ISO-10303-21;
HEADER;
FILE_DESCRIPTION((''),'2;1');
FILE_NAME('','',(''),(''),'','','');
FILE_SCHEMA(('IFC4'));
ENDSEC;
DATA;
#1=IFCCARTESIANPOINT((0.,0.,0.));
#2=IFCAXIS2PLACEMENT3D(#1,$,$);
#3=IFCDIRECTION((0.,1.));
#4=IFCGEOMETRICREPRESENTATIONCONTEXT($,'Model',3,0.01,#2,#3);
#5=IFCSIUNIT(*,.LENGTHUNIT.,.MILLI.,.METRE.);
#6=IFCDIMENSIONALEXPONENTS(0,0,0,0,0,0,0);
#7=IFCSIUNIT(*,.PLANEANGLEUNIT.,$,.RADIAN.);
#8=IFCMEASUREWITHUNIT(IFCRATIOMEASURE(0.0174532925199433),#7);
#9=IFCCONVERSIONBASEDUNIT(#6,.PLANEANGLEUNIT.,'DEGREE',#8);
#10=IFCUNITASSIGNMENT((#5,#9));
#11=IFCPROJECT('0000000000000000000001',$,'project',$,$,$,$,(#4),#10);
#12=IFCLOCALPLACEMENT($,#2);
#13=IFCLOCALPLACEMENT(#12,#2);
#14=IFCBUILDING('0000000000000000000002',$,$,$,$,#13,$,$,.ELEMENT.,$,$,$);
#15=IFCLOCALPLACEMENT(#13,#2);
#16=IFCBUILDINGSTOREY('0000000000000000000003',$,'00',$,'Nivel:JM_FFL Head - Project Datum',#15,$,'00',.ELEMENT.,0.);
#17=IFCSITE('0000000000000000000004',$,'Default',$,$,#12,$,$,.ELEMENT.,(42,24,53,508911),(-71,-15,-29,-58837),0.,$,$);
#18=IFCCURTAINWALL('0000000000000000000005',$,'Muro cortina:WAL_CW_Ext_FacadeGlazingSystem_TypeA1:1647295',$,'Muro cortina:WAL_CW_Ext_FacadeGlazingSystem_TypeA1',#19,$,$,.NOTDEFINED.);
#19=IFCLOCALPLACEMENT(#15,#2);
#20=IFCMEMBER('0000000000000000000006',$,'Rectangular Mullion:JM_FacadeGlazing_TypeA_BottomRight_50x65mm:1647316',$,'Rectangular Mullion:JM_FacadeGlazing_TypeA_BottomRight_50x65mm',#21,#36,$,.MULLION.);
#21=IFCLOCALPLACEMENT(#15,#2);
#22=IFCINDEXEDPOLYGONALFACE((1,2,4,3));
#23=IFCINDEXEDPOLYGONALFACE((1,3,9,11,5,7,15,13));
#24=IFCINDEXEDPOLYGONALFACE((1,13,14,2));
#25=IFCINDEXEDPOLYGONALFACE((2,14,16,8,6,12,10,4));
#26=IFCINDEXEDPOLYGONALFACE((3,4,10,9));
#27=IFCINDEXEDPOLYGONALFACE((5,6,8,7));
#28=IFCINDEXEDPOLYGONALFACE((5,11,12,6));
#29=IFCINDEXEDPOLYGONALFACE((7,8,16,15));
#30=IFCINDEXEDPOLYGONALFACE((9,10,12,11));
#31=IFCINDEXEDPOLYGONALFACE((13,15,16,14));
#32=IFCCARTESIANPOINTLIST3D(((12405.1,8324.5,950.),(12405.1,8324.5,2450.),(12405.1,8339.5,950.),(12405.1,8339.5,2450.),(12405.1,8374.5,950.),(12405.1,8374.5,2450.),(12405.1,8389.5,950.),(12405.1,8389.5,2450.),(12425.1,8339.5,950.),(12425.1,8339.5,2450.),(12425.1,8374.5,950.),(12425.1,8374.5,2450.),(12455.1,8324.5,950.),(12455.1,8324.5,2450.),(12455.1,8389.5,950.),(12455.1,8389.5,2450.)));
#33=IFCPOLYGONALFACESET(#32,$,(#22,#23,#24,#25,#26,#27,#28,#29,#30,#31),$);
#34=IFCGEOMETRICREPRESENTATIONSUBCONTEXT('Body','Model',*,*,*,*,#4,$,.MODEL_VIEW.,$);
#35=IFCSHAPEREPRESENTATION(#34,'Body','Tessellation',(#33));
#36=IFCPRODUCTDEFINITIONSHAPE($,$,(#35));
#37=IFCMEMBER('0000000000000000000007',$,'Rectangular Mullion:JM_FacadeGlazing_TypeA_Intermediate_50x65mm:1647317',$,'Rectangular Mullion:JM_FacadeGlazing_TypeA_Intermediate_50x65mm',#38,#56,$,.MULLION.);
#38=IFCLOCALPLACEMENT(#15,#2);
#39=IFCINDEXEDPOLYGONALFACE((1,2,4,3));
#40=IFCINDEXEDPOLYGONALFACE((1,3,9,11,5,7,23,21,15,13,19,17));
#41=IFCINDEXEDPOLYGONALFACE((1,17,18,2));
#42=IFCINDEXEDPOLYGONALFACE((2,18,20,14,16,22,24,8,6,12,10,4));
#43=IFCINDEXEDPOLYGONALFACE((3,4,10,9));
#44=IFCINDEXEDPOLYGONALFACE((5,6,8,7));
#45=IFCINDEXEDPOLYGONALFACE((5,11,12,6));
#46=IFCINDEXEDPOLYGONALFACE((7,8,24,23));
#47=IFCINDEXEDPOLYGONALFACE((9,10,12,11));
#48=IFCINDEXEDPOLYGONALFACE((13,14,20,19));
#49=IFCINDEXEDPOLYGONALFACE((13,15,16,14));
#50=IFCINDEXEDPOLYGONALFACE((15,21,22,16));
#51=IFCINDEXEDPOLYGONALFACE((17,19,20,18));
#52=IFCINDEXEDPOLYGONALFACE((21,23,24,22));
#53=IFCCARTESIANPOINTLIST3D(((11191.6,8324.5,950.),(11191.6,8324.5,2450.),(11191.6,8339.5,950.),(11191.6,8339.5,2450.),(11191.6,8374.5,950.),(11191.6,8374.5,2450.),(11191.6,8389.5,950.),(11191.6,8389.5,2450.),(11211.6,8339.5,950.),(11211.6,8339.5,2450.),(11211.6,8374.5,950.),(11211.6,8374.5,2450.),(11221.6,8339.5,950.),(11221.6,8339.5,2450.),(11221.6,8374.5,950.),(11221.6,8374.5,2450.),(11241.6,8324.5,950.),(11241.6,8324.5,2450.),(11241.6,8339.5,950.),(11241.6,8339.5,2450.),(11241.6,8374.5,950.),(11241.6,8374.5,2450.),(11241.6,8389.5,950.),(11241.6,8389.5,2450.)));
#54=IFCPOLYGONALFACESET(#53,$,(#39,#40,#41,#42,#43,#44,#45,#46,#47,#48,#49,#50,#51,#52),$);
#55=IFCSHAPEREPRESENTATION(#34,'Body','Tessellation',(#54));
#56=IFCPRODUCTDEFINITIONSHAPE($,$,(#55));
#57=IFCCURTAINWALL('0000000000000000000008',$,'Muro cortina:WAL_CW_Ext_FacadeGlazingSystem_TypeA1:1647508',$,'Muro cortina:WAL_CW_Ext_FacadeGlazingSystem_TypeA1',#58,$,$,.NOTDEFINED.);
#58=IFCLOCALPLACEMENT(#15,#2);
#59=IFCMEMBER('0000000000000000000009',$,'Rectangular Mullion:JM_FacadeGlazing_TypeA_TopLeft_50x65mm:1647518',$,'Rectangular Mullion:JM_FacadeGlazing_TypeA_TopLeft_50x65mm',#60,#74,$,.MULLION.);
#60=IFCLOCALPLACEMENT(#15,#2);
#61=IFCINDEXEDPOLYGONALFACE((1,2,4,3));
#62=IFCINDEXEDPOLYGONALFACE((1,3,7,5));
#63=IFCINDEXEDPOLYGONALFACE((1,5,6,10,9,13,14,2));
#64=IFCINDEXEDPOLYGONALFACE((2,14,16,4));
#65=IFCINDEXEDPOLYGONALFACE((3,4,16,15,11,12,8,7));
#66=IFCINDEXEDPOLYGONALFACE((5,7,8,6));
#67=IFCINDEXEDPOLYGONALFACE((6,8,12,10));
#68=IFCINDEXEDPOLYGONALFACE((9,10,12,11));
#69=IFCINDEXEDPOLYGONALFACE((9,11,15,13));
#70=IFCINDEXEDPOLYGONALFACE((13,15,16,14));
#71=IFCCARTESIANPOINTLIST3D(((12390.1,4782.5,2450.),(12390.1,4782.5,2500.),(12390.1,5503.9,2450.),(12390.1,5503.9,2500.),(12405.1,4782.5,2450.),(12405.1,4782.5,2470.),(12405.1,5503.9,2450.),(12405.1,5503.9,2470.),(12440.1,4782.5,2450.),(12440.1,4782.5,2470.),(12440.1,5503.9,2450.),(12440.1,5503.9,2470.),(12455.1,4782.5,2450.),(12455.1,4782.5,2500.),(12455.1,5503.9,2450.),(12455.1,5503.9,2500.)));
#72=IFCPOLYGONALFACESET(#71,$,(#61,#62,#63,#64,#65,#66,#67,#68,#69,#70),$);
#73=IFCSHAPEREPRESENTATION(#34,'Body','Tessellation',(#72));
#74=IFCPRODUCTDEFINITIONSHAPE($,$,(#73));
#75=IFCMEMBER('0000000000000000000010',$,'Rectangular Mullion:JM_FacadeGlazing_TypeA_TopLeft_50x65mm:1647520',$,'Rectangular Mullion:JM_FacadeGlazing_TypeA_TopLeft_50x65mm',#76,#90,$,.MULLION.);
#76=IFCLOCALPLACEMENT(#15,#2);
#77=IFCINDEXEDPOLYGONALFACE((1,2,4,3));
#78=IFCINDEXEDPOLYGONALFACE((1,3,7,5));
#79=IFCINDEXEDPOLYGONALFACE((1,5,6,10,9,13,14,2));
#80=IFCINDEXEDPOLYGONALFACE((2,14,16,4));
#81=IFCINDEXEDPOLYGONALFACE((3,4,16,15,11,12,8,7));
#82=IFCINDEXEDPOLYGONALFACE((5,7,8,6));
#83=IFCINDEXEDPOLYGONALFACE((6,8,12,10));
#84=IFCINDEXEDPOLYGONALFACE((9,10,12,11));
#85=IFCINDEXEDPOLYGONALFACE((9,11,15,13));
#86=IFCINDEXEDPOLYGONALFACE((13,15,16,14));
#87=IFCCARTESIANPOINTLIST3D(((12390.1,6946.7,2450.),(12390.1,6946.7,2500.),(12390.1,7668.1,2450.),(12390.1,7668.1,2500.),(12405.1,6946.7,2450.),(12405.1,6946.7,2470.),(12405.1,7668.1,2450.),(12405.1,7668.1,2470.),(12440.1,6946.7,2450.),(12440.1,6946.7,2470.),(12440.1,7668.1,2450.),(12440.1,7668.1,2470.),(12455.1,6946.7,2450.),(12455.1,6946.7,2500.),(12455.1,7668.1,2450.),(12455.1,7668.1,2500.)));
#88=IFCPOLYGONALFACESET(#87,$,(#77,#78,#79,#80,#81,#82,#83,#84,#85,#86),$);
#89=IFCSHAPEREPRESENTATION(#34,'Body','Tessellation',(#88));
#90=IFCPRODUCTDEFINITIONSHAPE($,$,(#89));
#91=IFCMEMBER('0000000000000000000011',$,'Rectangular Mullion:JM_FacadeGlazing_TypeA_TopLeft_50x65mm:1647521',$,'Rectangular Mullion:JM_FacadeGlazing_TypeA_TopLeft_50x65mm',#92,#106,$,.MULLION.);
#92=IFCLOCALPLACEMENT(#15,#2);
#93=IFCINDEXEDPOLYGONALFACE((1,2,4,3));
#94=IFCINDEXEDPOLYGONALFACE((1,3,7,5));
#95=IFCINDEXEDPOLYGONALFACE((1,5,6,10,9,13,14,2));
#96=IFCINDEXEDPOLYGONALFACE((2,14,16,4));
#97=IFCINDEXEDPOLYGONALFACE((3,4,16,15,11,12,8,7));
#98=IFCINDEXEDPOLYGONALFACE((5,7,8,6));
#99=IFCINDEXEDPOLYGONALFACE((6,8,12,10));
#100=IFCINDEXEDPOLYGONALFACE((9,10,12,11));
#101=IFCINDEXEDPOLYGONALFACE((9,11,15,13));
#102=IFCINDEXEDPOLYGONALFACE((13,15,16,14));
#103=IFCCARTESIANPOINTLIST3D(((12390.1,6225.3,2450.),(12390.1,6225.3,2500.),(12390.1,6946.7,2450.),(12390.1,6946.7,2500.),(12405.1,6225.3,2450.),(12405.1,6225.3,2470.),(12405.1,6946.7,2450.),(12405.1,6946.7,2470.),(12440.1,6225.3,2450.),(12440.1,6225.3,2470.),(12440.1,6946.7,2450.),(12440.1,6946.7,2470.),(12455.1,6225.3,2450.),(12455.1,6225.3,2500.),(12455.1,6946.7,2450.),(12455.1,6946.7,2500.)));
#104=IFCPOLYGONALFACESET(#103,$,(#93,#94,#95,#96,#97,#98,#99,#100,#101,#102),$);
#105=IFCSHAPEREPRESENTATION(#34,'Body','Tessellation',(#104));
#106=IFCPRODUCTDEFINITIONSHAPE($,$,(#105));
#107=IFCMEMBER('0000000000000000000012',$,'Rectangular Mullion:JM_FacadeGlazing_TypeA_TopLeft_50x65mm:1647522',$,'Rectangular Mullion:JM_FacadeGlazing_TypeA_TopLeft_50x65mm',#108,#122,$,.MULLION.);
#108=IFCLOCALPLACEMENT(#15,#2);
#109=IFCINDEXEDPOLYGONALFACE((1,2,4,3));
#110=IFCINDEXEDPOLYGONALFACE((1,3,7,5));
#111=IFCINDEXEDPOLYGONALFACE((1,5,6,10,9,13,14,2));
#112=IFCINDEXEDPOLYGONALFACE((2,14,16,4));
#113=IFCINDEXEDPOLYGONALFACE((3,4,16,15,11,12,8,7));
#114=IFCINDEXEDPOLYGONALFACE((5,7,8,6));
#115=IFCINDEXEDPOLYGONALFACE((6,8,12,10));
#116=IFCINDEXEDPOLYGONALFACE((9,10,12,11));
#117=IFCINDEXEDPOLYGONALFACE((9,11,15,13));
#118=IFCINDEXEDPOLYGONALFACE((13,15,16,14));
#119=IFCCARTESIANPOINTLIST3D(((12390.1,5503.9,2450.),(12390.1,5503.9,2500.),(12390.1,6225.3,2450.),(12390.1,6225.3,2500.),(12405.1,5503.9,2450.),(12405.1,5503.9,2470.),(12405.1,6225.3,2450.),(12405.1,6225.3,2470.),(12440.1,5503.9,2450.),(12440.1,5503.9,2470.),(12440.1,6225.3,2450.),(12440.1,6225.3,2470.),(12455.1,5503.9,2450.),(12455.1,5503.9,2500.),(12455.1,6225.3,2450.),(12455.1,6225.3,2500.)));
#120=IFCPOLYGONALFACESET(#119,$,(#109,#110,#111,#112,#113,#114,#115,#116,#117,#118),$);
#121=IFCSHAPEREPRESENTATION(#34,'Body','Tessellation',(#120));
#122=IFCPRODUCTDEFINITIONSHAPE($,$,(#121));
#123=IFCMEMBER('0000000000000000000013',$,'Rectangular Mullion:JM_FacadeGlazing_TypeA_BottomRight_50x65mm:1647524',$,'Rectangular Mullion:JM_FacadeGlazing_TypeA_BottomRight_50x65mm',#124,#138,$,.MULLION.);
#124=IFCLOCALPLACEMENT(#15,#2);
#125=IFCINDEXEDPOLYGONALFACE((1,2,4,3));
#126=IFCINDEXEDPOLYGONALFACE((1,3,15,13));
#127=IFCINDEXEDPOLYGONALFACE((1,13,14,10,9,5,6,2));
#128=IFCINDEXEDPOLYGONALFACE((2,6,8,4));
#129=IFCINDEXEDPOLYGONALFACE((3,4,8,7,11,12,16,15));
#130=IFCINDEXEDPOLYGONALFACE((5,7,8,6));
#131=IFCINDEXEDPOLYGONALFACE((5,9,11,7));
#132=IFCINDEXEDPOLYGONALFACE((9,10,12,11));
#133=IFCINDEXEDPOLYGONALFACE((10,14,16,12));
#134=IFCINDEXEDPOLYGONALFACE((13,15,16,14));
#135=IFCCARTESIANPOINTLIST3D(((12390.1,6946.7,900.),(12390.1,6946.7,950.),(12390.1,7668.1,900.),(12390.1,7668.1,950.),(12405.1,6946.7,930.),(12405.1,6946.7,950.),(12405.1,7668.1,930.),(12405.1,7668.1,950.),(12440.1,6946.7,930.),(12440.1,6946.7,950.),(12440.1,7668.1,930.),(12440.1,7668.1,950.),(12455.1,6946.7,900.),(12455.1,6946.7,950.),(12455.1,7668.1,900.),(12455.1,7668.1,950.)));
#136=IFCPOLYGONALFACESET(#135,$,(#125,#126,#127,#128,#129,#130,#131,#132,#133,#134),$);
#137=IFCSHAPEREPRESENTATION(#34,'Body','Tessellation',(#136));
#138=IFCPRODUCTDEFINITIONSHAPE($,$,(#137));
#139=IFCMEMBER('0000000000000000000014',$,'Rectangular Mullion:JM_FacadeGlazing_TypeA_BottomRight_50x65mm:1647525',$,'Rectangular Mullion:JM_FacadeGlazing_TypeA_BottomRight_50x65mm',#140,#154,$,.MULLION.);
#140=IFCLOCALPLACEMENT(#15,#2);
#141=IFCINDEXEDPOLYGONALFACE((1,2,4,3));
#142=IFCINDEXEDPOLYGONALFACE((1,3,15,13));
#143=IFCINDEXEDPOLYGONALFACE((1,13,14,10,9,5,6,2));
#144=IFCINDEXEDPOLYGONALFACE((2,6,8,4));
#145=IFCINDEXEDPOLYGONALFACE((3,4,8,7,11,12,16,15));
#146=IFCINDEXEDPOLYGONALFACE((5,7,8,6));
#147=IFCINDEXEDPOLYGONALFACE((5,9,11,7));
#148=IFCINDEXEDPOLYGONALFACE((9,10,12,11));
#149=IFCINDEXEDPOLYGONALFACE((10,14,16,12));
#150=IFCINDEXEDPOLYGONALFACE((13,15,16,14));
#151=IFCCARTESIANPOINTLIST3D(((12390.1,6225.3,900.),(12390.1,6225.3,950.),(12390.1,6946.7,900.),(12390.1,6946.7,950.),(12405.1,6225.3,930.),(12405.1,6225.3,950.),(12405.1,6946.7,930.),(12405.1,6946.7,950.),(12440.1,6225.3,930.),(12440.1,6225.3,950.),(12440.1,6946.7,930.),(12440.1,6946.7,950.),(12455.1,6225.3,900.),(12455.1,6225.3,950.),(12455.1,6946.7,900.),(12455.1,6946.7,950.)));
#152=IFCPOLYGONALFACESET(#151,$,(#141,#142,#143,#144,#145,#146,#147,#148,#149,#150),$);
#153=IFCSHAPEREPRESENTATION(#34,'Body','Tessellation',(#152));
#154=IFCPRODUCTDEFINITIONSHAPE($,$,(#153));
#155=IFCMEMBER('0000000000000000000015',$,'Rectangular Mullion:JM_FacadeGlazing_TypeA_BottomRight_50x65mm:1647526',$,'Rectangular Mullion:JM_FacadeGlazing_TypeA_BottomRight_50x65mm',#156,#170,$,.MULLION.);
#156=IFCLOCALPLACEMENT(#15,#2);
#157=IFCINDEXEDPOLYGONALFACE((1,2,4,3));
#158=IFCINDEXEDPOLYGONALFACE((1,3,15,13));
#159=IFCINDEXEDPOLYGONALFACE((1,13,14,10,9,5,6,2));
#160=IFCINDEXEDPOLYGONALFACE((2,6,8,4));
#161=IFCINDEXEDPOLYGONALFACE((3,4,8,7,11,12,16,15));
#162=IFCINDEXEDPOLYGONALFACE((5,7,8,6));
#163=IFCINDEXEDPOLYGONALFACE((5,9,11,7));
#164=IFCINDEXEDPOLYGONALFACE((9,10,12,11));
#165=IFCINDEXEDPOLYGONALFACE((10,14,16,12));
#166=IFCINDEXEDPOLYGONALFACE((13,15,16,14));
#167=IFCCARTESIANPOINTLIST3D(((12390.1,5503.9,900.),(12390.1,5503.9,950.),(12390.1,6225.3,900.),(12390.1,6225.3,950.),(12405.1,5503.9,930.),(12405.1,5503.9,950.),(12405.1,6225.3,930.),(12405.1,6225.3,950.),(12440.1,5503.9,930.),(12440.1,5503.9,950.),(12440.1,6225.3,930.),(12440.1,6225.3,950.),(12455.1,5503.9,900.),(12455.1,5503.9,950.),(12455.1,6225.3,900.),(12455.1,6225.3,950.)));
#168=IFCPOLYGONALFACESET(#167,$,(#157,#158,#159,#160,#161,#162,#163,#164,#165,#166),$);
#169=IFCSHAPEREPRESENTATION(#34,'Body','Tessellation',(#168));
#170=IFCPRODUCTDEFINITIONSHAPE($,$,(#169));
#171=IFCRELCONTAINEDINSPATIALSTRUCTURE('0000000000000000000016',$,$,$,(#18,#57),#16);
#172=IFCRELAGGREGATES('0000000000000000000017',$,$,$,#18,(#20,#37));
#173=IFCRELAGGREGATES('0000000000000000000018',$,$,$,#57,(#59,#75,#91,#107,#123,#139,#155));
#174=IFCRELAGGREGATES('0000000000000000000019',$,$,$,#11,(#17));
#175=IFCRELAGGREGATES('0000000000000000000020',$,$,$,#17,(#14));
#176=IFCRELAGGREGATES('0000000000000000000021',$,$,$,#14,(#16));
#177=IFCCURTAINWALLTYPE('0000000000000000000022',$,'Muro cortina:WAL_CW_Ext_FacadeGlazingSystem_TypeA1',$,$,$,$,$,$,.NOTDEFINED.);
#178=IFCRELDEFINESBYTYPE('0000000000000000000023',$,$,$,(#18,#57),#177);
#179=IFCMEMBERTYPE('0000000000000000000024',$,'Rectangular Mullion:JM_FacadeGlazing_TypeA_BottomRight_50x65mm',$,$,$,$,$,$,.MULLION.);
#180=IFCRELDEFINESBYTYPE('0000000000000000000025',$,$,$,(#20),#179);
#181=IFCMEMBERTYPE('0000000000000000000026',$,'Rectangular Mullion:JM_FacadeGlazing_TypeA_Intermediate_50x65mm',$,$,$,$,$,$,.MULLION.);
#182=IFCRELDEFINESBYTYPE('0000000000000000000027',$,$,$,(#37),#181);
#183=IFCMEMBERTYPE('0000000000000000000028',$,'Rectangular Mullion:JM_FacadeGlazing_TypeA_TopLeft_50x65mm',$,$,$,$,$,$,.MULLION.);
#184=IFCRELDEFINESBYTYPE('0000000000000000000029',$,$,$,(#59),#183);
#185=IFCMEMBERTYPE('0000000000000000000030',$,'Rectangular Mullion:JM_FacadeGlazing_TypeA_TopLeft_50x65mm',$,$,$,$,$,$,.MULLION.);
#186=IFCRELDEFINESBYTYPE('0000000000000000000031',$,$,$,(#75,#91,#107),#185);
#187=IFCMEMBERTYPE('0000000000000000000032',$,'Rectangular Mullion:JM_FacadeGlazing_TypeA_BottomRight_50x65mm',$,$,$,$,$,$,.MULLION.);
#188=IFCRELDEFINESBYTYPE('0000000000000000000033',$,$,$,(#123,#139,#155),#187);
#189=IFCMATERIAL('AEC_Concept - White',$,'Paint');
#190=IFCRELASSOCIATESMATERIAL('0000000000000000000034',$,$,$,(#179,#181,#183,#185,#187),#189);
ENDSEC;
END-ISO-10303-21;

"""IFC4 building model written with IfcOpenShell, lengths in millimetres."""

from ifc_helpers import new_model, entity, si_unit, converted_unit, direction, frame, origin, place, context, subcontext, project, spatial, indexed_curve, outline, extrude, source, transform, mapped, material, type_object, type_shapes, element, aggregate, save


model = new_model("IFC4")

# Units and contexts
model_context = context("Model", 3, precision=0.01, world=origin(), true_north=direction((0.0, 1.0)))
body_context = subcontext(model_context, "Body", "Model", "MODEL_VIEW")
ifc_project = project(units=[si_unit("LENGTHUNIT", "METRE", prefix="MILLI"), converted_unit("PLANEANGLEUNIT", "DEGREE", entity("IfcRatioMeasure", 0.0174532925199433), si_unit("PLANEANGLEUNIT", "RADIAN"), dimensions=[0, 0, 0, 0, 0, 0, 0])], contexts=[model_context])

# Site, building, storey
site_placement = place(None, origin())
site = spatial("IfcSite", under=ifc_project, at=site_placement, Name="Default", CompositionType="ELEMENT", RefLatitude=(42, 24, 53, 508911), RefLongitude=(-71, -15, -29, -58837), RefElevation=0.0)
building_placement = place(site_placement, origin())
building = spatial("IfcBuilding", under=site, at=building_placement, CompositionType="ELEMENT")
storey_placement = place(building_placement, origin())
storey = spatial("IfcBuildingStorey", under=building, at=storey_placement, Name="00", ObjectType="Nivel:JM_FFL Head - Project Datum", LongName="00", CompositionType="ELEMENT", Elevation=0.0)

# Curtain walls, members
curtain_wall_type = type_object("IfcCurtainWallType", Name="Muro cortina:WAL_CW_Ext_FacadeGlazingSystem_TypeA1", PredefinedType="NOTDEFINED")
curtain_wall_1_placement = place(storey_placement, origin())
curtain_wall_1 = element("IfcCurtainWall", 1, at=curtain_wall_1_placement, inside=storey, type_object=curtain_wall_type, Name="Muro cortina:WAL_CW_Ext_FacadeGlazingSystem_TypeA1:1647295", ObjectType="Muro cortina:WAL_CW_Ext_FacadeGlazingSystem_TypeA1", PredefinedType="NOTDEFINED")
ifc_material_1 = material(Name="AEC_Concept - White", Category="Paint")
member_type_1 = type_object("IfcMemberType", Name="Rectangular Mullion:JM_FacadeGlazing_TypeA_BottomRight_50x65mm", PredefinedType="MULLION", material=ifc_material_1)
shared_shape_1 = source(origin(), body_context, "Body", "SweptSolid", [
    extrude(outline(indexed_curve([(-32.5, -17.5), (-17.5, -17.5), (-17.5, 2.5), (17.5, 2.5), (17.5, -17.5), (32.5, -17.5), (32.5, 32.5), (-32.5, 32.5), (-32.5, -17.5)], self_intersect=False)), frame((-32.5, -32.5, -1500.0), z_axis=(0.0, 0.0, 1.0), x_axis=(0.0, -1.0, 0.0)), (0.0, 0.0, 1.0), 1500.0),
])
type_shapes(member_type_1, [shared_shape_1])
member_1_placement = place(curtain_wall_1_placement, frame((12455.1, 8389.5, 2450.0)))
member_1 = element("IfcMember", 2, at=member_1_placement, type_object=member_type_1, Name="Rectangular Mullion:JM_FacadeGlazing_TypeA_BottomRight_50x65mm:1647316", ObjectType="Rectangular Mullion:JM_FacadeGlazing_TypeA_BottomRight_50x65mm", PredefinedType="MULLION", context=body_context, shape_type="MappedRepresentation", body=[
    mapped(shared_shape_1, transform((0.0, 0.0, 0.0), scale=1.0)),
])
member_type_2 = type_object("IfcMemberType", Name="Rectangular Mullion:JM_FacadeGlazing_TypeA_Intermediate_50x65mm", PredefinedType="MULLION", material=ifc_material_1)
shared_shape_2 = source(origin(), body_context, "Body", "SweptSolid", [
    extrude(outline(indexed_curve([(-32.5, -25.0), (-17.5, -25.0), (-17.5, -5.0), (17.5, -5.0), (17.5, -25.0), (32.5, -25.0), (32.5, 25.0), (17.5, 25.0), (17.5, 5.0), (-17.5, 5.0), (-17.5, 25.0), (-32.5, 25.0), (-32.5, -25.0)], self_intersect=False)), frame((0.0, -32.5, -1500.0), z_axis=(0.0, 0.0, 1.0), x_axis=(0.0, -1.0, 0.0)), (0.0, 0.0, 1.0), 1500.0),
])
type_shapes(member_type_2, [shared_shape_2])
member_2_placement = place(curtain_wall_1_placement, frame((11216.6, 8389.5, 950.0), z_axis=(0.0, 0.0, -1.0), x_axis=(-1.0, 0.0, 0.0)))
member_2 = element("IfcMember", 3, at=member_2_placement, type_object=member_type_2, Name="Rectangular Mullion:JM_FacadeGlazing_TypeA_Intermediate_50x65mm:1647317", ObjectType="Rectangular Mullion:JM_FacadeGlazing_TypeA_Intermediate_50x65mm", PredefinedType="MULLION", context=body_context, shape_type="MappedRepresentation", body=[
    mapped(shared_shape_2, transform((0.0, 0.0, 0.0), scale=1.0)),
])
curtain_wall_2_placement = place(storey_placement, origin())
curtain_wall_2 = element("IfcCurtainWall", 4, at=curtain_wall_2_placement, inside=storey, type_object=curtain_wall_type, Name="Muro cortina:WAL_CW_Ext_FacadeGlazingSystem_TypeA1:1647508", ObjectType="Muro cortina:WAL_CW_Ext_FacadeGlazingSystem_TypeA1", PredefinedType="NOTDEFINED")
member_type_3 = type_object("IfcMemberType", Name="Rectangular Mullion:JM_FacadeGlazing_TypeA_TopLeft_50x65mm", PredefinedType="MULLION", material=ifc_material_1)
shared_shape_3 = source(origin(), body_context, "Body", "SweptSolid", [
    extrude(outline(indexed_curve([(-32.5, -17.5), (-17.5, -17.5), (-17.5, 2.5), (17.5, 2.5), (17.5, -17.5), (32.5, -17.5), (32.5, 32.5), (-32.5, 32.5), (-32.5, -17.5)], self_intersect=False)), frame((-32.5, 32.5, -721.4), z_axis=(0.0, 0.0, 1.0), x_axis=(0.0, -1.0, 0.0)), (0.0, 0.0, 1.0), 721.4),
])
type_shapes(member_type_3, [shared_shape_3])
member_3_placement = place(curtain_wall_2_placement, frame((12455.1, 4782.5, 2500.0), z_axis=(0.0, -1.0, 0.0), x_axis=(0.0, 0.0, 1.0)))
member_3 = element("IfcMember", 5, at=member_3_placement, type_object=member_type_3, Name="Rectangular Mullion:JM_FacadeGlazing_TypeA_TopLeft_50x65mm:1647518", ObjectType="Rectangular Mullion:JM_FacadeGlazing_TypeA_TopLeft_50x65mm", PredefinedType="MULLION", context=body_context, shape_type="MappedRepresentation", body=[
    mapped(shared_shape_3, transform((0.0, 0.0, 0.0), scale=1.0)),
])
member_type_4 = type_object("IfcMemberType", Name="Rectangular Mullion:JM_FacadeGlazing_TypeA_TopLeft_50x65mm", PredefinedType="MULLION", material=ifc_material_1)
shared_shape_4 = source(origin(), body_context, "Body", "SweptSolid", [
    extrude(outline(indexed_curve([(-32.5, -17.5), (-17.5, -17.5), (-17.5, 2.5), (17.5, 2.5), (17.5, -17.5), (32.5, -17.5), (32.5, 32.5), (-32.5, 32.5), (-32.5, -17.5)], self_intersect=False)), frame((-32.5, 32.5, -721.4), z_axis=(0.0, 0.0, 1.0), x_axis=(0.0, -1.0, 0.0)), (0.0, 0.0, 1.0), 721.4),
])
type_shapes(member_type_4, [shared_shape_4])
member_4_placement = place(curtain_wall_2_placement, frame((12455.1, 6946.7, 2500.0), z_axis=(0.0, -1.0, 0.0), x_axis=(0.0, 0.0, 1.0)))
member_4 = element("IfcMember", 6, at=member_4_placement, type_object=member_type_4, Name="Rectangular Mullion:JM_FacadeGlazing_TypeA_TopLeft_50x65mm:1647520", ObjectType="Rectangular Mullion:JM_FacadeGlazing_TypeA_TopLeft_50x65mm", PredefinedType="MULLION", context=body_context, shape_type="MappedRepresentation", body=[
    mapped(shared_shape_4, transform((0.0, 0.0, 0.0), scale=1.0)),
])
member_5_placement = place(curtain_wall_2_placement, frame((12455.1, 6225.3, 2500.0), z_axis=(0.0, -1.0, 0.0), x_axis=(0.0, 0.0, 1.0)))
member_5 = element("IfcMember", 7, at=member_5_placement, type_object=member_type_4, Name="Rectangular Mullion:JM_FacadeGlazing_TypeA_TopLeft_50x65mm:1647521", ObjectType="Rectangular Mullion:JM_FacadeGlazing_TypeA_TopLeft_50x65mm", PredefinedType="MULLION", context=body_context, shape_type="MappedRepresentation", body=[
    mapped(shared_shape_4, transform((0.0, 0.0, 0.0), scale=1.0)),
])
member_6_placement = place(curtain_wall_2_placement, frame((12455.1, 5503.9, 2500.0), z_axis=(0.0, -1.0, 0.0), x_axis=(0.0, 0.0, 1.0)))
member_6 = element("IfcMember", 8, at=member_6_placement, type_object=member_type_4, Name="Rectangular Mullion:JM_FacadeGlazing_TypeA_TopLeft_50x65mm:1647522", ObjectType="Rectangular Mullion:JM_FacadeGlazing_TypeA_TopLeft_50x65mm", PredefinedType="MULLION", context=body_context, shape_type="MappedRepresentation", body=[
    mapped(shared_shape_4, transform((0.0, 0.0, 0.0), scale=1.0)),
])
member_type_5 = type_object("IfcMemberType", Name="Rectangular Mullion:JM_FacadeGlazing_TypeA_BottomRight_50x65mm", PredefinedType="MULLION", material=ifc_material_1)
shared_shape_5 = source(origin(), body_context, "Body", "SweptSolid", [
    extrude(outline(indexed_curve([(-32.5, -17.5), (-17.5, -17.5), (-17.5, 2.5), (17.5, 2.5), (17.5, -17.5), (32.5, -17.5), (32.5, 32.5), (-32.5, 32.5), (-32.5, -17.5)], self_intersect=False)), frame((-32.5, 32.5, -721.4), z_axis=(0.0, 0.0, 1.0), x_axis=(0.0, -1.0, 0.0)), (0.0, 0.0, 1.0), 721.4),
])
type_shapes(member_type_5, [shared_shape_5])
member_7_placement = place(curtain_wall_2_placement, frame((12455.1, 7668.1, 900.0), z_axis=(0.0, 1.0, 0.0), x_axis=(0.0, 0.0, -1.0)))
member_7 = element("IfcMember", 9, at=member_7_placement, type_object=member_type_5, Name="Rectangular Mullion:JM_FacadeGlazing_TypeA_BottomRight_50x65mm:1647524", ObjectType="Rectangular Mullion:JM_FacadeGlazing_TypeA_BottomRight_50x65mm", PredefinedType="MULLION", context=body_context, shape_type="MappedRepresentation", body=[
    mapped(shared_shape_5, transform((0.0, 0.0, 0.0), scale=1.0)),
])
member_8_placement = place(curtain_wall_2_placement, frame((12455.1, 6946.7, 900.0), z_axis=(0.0, 1.0, 0.0), x_axis=(0.0, 0.0, -1.0)))
member_8 = element("IfcMember", 10, at=member_8_placement, type_object=member_type_5, Name="Rectangular Mullion:JM_FacadeGlazing_TypeA_BottomRight_50x65mm:1647525", ObjectType="Rectangular Mullion:JM_FacadeGlazing_TypeA_BottomRight_50x65mm", PredefinedType="MULLION", context=body_context, shape_type="MappedRepresentation", body=[
    mapped(shared_shape_5, transform((0.0, 0.0, 0.0), scale=1.0)),
])
member_9_placement = place(curtain_wall_2_placement, frame((12455.1, 6225.3, 900.0), z_axis=(0.0, 1.0, 0.0), x_axis=(0.0, 0.0, -1.0)))
member_9 = element("IfcMember", 11, at=member_9_placement, type_object=member_type_5, Name="Rectangular Mullion:JM_FacadeGlazing_TypeA_BottomRight_50x65mm:1647526", ObjectType="Rectangular Mullion:JM_FacadeGlazing_TypeA_BottomRight_50x65mm", PredefinedType="MULLION", context=body_context, shape_type="MappedRepresentation", body=[
    mapped(shared_shape_5, transform((0.0, 0.0, 0.0), scale=1.0)),
])

aggregate(curtain_wall_1, [member_1, member_2])
aggregate(curtain_wall_2, [member_3, member_4, member_5, member_6, member_7, member_8, member_9])

save(model, "model.ifc")
